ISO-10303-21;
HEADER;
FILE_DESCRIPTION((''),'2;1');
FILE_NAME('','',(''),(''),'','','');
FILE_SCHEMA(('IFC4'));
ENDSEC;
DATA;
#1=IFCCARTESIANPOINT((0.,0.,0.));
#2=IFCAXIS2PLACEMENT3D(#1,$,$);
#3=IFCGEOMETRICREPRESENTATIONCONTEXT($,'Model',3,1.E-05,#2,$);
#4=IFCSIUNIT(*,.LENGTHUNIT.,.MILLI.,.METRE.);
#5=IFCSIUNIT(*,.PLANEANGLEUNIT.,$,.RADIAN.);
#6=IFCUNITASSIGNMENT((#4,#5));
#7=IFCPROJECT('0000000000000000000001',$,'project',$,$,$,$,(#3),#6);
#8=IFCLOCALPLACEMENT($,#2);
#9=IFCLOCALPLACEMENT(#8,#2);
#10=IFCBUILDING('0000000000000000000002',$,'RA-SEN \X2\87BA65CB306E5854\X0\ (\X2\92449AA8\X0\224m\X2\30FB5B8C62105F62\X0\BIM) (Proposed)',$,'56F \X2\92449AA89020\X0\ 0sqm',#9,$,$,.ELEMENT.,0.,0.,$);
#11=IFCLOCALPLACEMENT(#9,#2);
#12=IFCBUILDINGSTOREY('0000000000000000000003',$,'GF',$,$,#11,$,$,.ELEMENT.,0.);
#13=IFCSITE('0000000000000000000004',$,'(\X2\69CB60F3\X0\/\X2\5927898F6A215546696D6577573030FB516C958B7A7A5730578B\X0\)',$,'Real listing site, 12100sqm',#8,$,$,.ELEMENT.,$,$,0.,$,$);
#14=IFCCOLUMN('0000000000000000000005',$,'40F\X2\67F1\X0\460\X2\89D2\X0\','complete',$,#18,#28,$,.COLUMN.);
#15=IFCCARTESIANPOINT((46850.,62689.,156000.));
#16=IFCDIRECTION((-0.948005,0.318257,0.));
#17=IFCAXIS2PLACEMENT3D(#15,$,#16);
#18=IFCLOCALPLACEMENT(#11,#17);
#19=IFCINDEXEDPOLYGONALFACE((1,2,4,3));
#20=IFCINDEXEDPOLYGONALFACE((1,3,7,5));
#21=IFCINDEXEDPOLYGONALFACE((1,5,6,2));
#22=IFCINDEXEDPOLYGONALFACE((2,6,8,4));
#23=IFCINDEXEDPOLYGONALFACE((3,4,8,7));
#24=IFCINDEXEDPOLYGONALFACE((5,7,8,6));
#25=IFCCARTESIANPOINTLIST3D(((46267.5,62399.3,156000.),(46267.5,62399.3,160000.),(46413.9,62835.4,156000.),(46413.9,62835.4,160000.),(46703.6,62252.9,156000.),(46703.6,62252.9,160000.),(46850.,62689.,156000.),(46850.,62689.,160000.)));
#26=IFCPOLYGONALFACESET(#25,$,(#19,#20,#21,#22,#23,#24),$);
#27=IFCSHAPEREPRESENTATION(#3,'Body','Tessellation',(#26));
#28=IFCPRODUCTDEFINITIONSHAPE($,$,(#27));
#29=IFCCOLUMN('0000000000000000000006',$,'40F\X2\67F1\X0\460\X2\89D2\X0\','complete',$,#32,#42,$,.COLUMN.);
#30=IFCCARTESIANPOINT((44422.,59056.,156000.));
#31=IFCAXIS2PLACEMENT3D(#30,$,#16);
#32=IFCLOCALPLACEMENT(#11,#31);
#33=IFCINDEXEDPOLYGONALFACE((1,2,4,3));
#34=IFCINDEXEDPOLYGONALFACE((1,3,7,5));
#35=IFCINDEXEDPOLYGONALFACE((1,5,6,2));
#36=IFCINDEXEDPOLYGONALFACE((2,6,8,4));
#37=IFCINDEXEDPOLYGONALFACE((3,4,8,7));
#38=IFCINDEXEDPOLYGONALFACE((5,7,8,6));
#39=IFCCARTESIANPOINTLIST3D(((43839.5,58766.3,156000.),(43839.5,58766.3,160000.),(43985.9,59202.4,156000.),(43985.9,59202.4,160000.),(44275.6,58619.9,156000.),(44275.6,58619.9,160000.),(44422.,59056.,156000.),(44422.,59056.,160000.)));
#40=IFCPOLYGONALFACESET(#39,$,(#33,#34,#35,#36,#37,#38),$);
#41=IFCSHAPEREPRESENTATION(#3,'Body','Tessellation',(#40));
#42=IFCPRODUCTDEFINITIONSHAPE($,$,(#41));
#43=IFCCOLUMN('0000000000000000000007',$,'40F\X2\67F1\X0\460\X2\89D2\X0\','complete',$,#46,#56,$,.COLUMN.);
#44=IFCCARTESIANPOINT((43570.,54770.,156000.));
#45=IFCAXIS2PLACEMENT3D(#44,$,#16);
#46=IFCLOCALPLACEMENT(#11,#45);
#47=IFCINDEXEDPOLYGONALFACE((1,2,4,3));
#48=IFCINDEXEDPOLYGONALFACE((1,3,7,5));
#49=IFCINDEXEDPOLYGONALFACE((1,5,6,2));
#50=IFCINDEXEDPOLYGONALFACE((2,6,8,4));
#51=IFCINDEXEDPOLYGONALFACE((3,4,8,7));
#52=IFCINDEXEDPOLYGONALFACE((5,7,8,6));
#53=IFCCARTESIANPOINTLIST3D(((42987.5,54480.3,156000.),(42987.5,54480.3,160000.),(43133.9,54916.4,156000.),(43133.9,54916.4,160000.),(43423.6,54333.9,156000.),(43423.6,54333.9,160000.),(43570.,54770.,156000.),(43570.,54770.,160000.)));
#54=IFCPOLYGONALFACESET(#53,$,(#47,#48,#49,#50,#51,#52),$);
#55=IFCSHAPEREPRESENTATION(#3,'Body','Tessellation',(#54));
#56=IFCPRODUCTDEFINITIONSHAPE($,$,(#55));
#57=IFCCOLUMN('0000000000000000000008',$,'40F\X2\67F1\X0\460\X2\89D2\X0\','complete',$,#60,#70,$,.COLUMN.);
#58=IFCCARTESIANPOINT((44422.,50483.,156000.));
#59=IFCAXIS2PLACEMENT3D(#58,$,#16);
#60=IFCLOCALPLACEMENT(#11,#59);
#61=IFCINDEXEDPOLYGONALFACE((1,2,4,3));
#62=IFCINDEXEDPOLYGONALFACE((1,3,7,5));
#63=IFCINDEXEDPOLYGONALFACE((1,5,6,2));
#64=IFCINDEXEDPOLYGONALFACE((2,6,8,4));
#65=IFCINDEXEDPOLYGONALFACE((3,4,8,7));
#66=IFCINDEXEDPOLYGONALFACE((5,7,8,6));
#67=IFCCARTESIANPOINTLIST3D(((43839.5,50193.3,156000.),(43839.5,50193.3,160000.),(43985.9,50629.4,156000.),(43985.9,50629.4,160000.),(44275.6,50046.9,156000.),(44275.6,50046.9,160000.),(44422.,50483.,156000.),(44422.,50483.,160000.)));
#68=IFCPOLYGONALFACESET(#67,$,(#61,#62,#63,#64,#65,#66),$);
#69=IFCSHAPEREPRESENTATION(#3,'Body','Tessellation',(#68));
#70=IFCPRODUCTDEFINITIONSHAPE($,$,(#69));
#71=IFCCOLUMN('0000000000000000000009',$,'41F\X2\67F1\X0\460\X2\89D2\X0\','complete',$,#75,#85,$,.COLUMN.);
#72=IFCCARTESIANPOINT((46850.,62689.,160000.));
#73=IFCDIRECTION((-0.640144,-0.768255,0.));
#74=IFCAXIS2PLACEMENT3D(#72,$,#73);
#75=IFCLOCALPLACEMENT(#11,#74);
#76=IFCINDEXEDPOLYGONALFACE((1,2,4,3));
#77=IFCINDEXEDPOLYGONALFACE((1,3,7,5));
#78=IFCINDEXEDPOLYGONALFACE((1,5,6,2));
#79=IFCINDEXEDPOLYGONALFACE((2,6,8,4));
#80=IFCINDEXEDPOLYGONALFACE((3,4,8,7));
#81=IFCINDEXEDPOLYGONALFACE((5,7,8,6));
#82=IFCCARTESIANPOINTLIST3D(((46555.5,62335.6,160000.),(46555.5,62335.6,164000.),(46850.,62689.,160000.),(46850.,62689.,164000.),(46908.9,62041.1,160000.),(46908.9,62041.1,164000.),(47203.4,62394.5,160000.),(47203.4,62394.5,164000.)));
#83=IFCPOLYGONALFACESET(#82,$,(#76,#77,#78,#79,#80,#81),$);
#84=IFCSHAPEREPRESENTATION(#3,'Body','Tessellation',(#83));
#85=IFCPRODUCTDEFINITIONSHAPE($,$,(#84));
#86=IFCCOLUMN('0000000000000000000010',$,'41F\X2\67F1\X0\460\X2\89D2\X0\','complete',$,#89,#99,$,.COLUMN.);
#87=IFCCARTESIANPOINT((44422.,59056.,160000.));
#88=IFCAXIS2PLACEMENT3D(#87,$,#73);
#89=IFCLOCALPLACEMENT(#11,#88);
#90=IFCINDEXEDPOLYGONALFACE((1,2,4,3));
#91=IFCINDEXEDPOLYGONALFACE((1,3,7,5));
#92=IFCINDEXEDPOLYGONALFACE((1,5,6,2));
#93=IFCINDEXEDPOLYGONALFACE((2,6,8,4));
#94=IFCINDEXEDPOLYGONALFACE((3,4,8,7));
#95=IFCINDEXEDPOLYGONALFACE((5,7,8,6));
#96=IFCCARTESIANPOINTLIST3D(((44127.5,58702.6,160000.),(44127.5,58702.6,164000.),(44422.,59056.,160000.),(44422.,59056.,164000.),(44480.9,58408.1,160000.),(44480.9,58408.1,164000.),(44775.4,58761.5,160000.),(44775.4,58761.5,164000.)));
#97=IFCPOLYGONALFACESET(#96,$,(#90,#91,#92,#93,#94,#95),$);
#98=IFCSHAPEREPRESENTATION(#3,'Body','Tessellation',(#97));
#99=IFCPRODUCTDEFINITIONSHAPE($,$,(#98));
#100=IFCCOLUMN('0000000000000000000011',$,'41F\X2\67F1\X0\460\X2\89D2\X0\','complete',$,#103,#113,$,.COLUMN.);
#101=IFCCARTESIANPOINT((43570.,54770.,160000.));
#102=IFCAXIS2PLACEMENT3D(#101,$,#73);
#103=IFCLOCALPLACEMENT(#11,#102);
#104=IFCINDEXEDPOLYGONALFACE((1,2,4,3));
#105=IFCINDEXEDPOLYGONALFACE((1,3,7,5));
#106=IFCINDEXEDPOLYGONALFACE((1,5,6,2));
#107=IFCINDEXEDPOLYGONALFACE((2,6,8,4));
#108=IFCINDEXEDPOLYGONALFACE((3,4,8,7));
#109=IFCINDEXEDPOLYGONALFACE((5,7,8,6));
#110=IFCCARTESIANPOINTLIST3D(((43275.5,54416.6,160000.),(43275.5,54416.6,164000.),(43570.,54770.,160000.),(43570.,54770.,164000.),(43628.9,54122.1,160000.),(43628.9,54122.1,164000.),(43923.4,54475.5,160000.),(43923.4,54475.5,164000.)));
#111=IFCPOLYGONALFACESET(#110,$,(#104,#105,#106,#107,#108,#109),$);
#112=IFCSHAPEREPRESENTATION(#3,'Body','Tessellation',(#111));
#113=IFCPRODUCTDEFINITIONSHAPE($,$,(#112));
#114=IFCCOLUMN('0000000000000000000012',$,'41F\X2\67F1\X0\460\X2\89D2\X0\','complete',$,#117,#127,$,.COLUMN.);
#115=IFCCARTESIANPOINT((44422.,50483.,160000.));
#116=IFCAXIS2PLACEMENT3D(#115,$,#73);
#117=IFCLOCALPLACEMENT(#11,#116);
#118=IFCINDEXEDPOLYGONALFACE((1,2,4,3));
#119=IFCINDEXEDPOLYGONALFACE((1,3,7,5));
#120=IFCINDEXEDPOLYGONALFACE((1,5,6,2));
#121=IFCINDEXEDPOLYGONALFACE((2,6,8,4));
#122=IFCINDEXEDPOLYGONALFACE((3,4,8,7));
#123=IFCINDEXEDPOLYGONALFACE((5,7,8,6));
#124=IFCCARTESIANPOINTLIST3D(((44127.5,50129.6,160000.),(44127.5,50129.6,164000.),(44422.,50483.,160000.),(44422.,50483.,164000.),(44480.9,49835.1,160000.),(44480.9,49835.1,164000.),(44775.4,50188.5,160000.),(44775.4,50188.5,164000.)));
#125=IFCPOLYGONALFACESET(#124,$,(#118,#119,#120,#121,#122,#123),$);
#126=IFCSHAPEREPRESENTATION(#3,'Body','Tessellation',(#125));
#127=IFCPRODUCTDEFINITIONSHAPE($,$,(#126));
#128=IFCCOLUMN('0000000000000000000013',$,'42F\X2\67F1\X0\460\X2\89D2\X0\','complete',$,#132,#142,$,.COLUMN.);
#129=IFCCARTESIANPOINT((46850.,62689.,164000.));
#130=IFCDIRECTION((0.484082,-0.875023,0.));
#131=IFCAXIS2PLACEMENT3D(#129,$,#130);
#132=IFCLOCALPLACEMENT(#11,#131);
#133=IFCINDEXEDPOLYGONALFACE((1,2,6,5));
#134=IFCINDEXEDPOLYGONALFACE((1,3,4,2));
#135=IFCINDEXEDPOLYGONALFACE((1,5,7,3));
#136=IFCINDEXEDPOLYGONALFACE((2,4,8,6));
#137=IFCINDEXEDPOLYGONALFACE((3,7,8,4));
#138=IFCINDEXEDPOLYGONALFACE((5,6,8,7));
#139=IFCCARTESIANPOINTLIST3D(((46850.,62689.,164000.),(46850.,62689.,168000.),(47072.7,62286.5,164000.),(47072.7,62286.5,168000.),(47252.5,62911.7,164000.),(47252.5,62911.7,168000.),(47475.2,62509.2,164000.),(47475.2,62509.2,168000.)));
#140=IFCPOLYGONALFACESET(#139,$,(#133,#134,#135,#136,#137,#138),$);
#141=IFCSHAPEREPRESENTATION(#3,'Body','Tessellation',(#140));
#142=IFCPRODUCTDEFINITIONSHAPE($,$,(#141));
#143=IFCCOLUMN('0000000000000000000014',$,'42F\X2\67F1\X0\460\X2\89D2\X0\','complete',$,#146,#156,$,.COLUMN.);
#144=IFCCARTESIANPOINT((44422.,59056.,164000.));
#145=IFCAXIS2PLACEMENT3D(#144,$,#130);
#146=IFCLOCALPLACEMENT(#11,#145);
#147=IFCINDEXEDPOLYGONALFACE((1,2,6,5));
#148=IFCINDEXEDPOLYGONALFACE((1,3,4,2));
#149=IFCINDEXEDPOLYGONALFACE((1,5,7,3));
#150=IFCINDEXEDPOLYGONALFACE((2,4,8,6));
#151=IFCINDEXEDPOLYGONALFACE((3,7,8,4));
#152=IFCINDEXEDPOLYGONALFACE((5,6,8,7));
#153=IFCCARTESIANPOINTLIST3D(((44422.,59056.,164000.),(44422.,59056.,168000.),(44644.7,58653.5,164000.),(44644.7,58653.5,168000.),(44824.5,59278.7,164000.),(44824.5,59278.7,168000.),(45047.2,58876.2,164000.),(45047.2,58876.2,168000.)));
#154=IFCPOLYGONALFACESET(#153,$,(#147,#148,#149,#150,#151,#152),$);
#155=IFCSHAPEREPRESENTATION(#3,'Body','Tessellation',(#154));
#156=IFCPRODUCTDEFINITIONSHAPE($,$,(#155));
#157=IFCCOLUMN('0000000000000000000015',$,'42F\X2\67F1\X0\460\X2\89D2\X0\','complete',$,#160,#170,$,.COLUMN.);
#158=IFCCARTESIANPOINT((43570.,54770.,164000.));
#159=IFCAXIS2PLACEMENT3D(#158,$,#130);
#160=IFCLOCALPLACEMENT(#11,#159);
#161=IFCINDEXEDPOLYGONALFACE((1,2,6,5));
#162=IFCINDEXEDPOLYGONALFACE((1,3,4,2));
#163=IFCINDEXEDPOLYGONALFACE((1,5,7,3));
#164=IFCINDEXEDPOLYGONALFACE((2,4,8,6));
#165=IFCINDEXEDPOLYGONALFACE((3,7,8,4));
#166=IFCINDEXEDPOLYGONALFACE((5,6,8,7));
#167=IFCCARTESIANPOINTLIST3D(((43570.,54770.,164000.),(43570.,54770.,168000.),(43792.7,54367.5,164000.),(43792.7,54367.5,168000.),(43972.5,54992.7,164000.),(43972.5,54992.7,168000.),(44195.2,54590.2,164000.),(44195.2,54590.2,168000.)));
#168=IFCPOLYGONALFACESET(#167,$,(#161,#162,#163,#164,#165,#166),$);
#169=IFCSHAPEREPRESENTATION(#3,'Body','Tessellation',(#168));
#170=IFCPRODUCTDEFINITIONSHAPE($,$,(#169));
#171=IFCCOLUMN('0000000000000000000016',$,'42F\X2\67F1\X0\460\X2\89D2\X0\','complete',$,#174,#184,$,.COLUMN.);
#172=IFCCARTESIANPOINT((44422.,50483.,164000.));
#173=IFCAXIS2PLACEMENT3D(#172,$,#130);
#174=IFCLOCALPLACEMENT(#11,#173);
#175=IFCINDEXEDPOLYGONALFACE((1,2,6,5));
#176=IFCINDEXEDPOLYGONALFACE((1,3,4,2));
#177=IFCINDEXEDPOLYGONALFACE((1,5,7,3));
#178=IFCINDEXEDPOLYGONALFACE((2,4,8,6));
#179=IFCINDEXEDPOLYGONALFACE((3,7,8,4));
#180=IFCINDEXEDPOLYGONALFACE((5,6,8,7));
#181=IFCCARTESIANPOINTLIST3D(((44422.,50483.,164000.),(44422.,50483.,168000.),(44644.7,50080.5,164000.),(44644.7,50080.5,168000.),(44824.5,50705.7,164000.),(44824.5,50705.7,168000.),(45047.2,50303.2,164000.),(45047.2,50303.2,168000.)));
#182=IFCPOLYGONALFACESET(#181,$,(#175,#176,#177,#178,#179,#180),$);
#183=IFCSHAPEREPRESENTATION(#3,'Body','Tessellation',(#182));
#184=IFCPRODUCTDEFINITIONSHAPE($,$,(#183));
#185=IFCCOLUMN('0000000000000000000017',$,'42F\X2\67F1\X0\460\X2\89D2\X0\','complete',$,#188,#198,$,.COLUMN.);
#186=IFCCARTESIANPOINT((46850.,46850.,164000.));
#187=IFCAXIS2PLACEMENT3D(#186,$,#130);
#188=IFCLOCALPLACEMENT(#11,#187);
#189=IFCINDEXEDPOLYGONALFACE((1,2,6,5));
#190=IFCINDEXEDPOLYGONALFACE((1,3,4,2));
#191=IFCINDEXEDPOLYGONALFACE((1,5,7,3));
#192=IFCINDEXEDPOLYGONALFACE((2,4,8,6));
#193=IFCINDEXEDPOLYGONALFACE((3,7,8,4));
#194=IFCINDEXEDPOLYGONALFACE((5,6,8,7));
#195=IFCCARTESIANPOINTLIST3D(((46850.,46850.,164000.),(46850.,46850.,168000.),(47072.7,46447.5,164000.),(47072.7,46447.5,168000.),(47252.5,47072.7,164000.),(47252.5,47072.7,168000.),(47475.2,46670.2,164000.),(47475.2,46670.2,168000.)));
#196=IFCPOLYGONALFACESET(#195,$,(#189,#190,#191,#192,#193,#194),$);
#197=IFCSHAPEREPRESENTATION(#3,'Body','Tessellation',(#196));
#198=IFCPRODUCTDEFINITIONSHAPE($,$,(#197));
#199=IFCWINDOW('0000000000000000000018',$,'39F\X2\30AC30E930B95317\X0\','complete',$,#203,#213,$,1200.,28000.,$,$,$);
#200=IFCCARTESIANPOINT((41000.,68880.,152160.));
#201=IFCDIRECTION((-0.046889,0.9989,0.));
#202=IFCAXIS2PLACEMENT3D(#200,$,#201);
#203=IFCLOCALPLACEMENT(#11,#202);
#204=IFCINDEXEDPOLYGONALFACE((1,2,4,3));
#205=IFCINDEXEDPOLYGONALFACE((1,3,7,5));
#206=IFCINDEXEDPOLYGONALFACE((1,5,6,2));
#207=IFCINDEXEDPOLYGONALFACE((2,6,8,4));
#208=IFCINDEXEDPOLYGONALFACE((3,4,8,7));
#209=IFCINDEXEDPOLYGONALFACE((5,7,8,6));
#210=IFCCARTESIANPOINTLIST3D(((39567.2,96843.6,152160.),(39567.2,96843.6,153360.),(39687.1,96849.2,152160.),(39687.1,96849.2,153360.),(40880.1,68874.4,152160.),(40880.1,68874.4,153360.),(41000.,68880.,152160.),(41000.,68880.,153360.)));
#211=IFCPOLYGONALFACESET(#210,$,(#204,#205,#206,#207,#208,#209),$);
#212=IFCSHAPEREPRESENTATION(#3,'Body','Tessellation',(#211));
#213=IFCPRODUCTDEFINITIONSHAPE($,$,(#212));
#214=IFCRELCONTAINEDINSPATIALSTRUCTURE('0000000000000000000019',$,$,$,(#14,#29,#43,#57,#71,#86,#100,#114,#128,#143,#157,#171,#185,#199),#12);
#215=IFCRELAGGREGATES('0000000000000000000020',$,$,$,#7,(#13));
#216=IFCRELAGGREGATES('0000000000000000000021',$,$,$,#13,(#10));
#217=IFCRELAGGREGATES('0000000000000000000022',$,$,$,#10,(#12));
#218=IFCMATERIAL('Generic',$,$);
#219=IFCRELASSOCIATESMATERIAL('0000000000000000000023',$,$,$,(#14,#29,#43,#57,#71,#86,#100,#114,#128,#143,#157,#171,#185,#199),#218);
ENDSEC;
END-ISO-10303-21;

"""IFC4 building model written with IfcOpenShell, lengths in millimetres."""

from ifc_helpers import new_model, si_unit, frame, frame_2d, origin, place, context, project, spatial, rectangle, extrude, material, element, save


model = new_model("IFC4")

# Units and contexts
model_context = context("Model", 3, precision=1e-05, world=origin())
ifc_project = project(units=[si_unit("LENGTHUNIT", "METRE", prefix="MILLI"), si_unit("PLANEANGLEUNIT", "RADIAN")], contexts=[model_context])

# Site, building, storey
site_placement = place(None, origin())
site = spatial("IfcSite", under=ifc_project, at=site_placement, Name="(構想/大規模商業敷地・公開空地型)", ObjectType="Real listing site, 12100sqm", CompositionType="ELEMENT", RefElevation=0.0)
building_placement = place(site_placement, origin())
building = spatial("IfcBuilding", under=site, at=building_placement, Name="RA-SEN 螺旋の塔 (鉄骨224m・完成形BIM) (Proposed)", ObjectType="56F 鉄骨造 0sqm", CompositionType="ELEMENT", ElevationOfRefHeight=0.0, ElevationOfTerrain=0.0)
storey_placement = place(building_placement, origin())
storey = spatial("IfcBuildingStorey", under=building, at=storey_placement, Name="GF", CompositionType="ELEMENT", Elevation=0.0)

# Columns
ifc_material = material(Name="Generic")
column_1_placement = place(storey_placement, frame((46850.0, 62689.0, 156000.0), x_axis=(-0.948005, 0.318257, 0.0)))
element("IfcColumn", 1, at=column_1_placement, inside=storey, material=ifc_material, Name="40F柱460角", Description="complete", PredefinedType="COLUMN", context=model_context, shape_type="SweptSolid", body=[
    extrude(rectangle(XDim=460.0, YDim=460.0, at=frame_2d((230.0, 230.0))), frame((46850.0, 62689.0, 156000.0), x_axis=(-0.948005, 0.318257, 0.0)), (0.0, 0.0, 1.0), 4000.0),
])
column_2_placement = place(storey_placement, frame((44422.0, 59056.0, 156000.0), x_axis=(-0.948005, 0.318257, 0.0)))
element("IfcColumn", 2, at=column_2_placement, inside=storey, material=ifc_material, Name="40F柱460角", Description="complete", PredefinedType="COLUMN", context=model_context, shape_type="SweptSolid", body=[
    extrude(rectangle(XDim=460.0, YDim=460.0, at=frame_2d((230.0, 230.0))), frame((44422.0, 59056.0, 156000.0), x_axis=(-0.948005, 0.318257, 0.0)), (0.0, 0.0, 1.0), 4000.0),
])
column_3_placement = place(storey_placement, frame((43570.0, 54770.0, 156000.0), x_axis=(-0.948005, 0.318257, 0.0)))
element("IfcColumn", 3, at=column_3_placement, inside=storey, material=ifc_material, Name="40F柱460角", Description="complete", PredefinedType="COLUMN", context=model_context, shape_type="SweptSolid", body=[
    extrude(rectangle(XDim=460.0, YDim=460.0, at=frame_2d((230.0, 230.0))), frame((43570.0, 54770.0, 156000.0), x_axis=(-0.948005, 0.318257, 0.0)), (0.0, 0.0, 1.0), 4000.0),
])
column_4_placement = place(storey_placement, frame((44422.0, 50483.0, 156000.0), x_axis=(-0.948005, 0.318257, 0.0)))
element("IfcColumn", 4, at=column_4_placement, inside=storey, material=ifc_material, Name="40F柱460角", Description="complete", PredefinedType="COLUMN", context=model_context, shape_type="SweptSolid", body=[
    extrude(rectangle(XDim=460.0, YDim=460.0, at=frame_2d((230.0, 230.0))), frame((44422.0, 50483.0, 156000.0), x_axis=(-0.948005, 0.318257, 0.0)), (0.0, 0.0, 1.0), 4000.0),
])
column_5_placement = place(storey_placement, frame((46850.0, 62689.0, 160000.0), x_axis=(-0.640144, -0.768255, 0.0)))
element("IfcColumn", 5, at=column_5_placement, inside=storey, material=ifc_material, Name="41F柱460角", Description="complete", PredefinedType="COLUMN", context=model_context, shape_type="SweptSolid", body=[
    extrude(rectangle(XDim=460.0, YDim=460.0, at=frame_2d((230.0, 230.0))), frame((46850.0, 62689.0, 160000.0), x_axis=(-0.640144, -0.768255, 0.0)), (0.0, 0.0, 1.0), 4000.0),
])
column_6_placement = place(storey_placement, frame((44422.0, 59056.0, 160000.0), x_axis=(-0.640144, -0.768255, 0.0)))
element("IfcColumn", 6, at=column_6_placement, inside=storey, material=ifc_material, Name="41F柱460角", Description="complete", PredefinedType="COLUMN", context=model_context, shape_type="SweptSolid", body=[
    extrude(rectangle(XDim=460.0, YDim=460.0, at=frame_2d((230.0, 230.0))), frame((44422.0, 59056.0, 160000.0), x_axis=(-0.640144, -0.768255, 0.0)), (0.0, 0.0, 1.0), 4000.0),
])
column_7_placement = place(storey_placement, frame((43570.0, 54770.0, 160000.0), x_axis=(-0.640144, -0.768255, 0.0)))
element("IfcColumn", 7, at=column_7_placement, inside=storey, material=ifc_material, Name="41F柱460角", Description="complete", PredefinedType="COLUMN", context=model_context, shape_type="SweptSolid", body=[
    extrude(rectangle(XDim=460.0, YDim=460.0, at=frame_2d((230.0, 230.0))), frame((43570.0, 54770.0, 160000.0), x_axis=(-0.640144, -0.768255, 0.0)), (0.0, 0.0, 1.0), 4000.0),
])
column_8_placement = place(storey_placement, frame((44422.0, 50483.0, 160000.0), x_axis=(-0.640144, -0.768255, 0.0)))
element("IfcColumn", 8, at=column_8_placement, inside=storey, material=ifc_material, Name="41F柱460角", Description="complete", PredefinedType="COLUMN", context=model_context, shape_type="SweptSolid", body=[
    extrude(rectangle(XDim=460.0, YDim=460.0, at=frame_2d((230.0, 230.0))), frame((44422.0, 50483.0, 160000.0), x_axis=(-0.640144, -0.768255, 0.0)), (0.0, 0.0, 1.0), 4000.0),
])
column_9_placement = place(storey_placement, frame((46850.0, 62689.0, 164000.0), x_axis=(0.484082, -0.875023, 0.0)))
element("IfcColumn", 9, at=column_9_placement, inside=storey, material=ifc_material, Name="42F柱460角", Description="complete", PredefinedType="COLUMN", context=model_context, shape_type="SweptSolid", body=[
    extrude(rectangle(XDim=460.0, YDim=460.0, at=frame_2d((230.0, 230.0))), frame((46850.0, 62689.0, 164000.0), x_axis=(0.484082, -0.875023, 0.0)), (0.0, 0.0, 1.0), 4000.0),
])
column_10_placement = place(storey_placement, frame((44422.0, 59056.0, 164000.0), x_axis=(0.484082, -0.875023, 0.0)))
element("IfcColumn", 10, at=column_10_placement, inside=storey, material=ifc_material, Name="42F柱460角", Description="complete", PredefinedType="COLUMN", context=model_context, shape_type="SweptSolid", body=[
    extrude(rectangle(XDim=460.0, YDim=460.0, at=frame_2d((230.0, 230.0))), frame((44422.0, 59056.0, 164000.0), x_axis=(0.484082, -0.875023, 0.0)), (0.0, 0.0, 1.0), 4000.0),
])
column_11_placement = place(storey_placement, frame((43570.0, 54770.0, 164000.0), x_axis=(0.484082, -0.875023, 0.0)))
element("IfcColumn", 11, at=column_11_placement, inside=storey, material=ifc_material, Name="42F柱460角", Description="complete", PredefinedType="COLUMN", context=model_context, shape_type="SweptSolid", body=[
    extrude(rectangle(XDim=460.0, YDim=460.0, at=frame_2d((230.0, 230.0))), frame((43570.0, 54770.0, 164000.0), x_axis=(0.484082, -0.875023, 0.0)), (0.0, 0.0, 1.0), 4000.0),
])
column_12_placement = place(storey_placement, frame((44422.0, 50483.0, 164000.0), x_axis=(0.484082, -0.875023, 0.0)))
element("IfcColumn", 12, at=column_12_placement, inside=storey, material=ifc_material, Name="42F柱460角", Description="complete", PredefinedType="COLUMN", context=model_context, shape_type="SweptSolid", body=[
    extrude(rectangle(XDim=460.0, YDim=460.0, at=frame_2d((230.0, 230.0))), frame((44422.0, 50483.0, 164000.0), x_axis=(0.484082, -0.875023, 0.0)), (0.0, 0.0, 1.0), 4000.0),
])
column_13_placement = place(storey_placement, frame((46850.0, 46850.0, 164000.0), x_axis=(0.484082, -0.875023, 0.0)))
element("IfcColumn", 13, at=column_13_placement, inside=storey, material=ifc_material, Name="42F柱460角", Description="complete", PredefinedType="COLUMN", context=model_context, shape_type="SweptSolid", body=[
    extrude(rectangle(XDim=460.0, YDim=460.0, at=frame_2d((230.0, 230.0))), frame((46850.0, 46850.0, 164000.0), x_axis=(0.484082, -0.875023, 0.0)), (0.0, 0.0, 1.0), 4000.0),
])

# Window
window_1_placement = place(storey_placement, frame((41000.0, 68880.0, 152160.0), x_axis=(-0.046889, 0.9989, 0.0)))
element("IfcWindow", 14, at=window_1_placement, inside=storey, material=ifc_material, Name="39Fガラス北", Description="complete", OverallHeight=1200.0, OverallWidth=28000.0, context=model_context, shape_type="SweptSolid", body=[
    extrude(rectangle(XDim=28000.0, YDim=120.0, at=frame_2d((14000.0, 60.0))), frame((41000.0, 68880.0, 152160.0), x_axis=(-0.046889, 0.9989, 0.0)), (0.0, 0.0, 1.0), 1200.0),
])

save(model, "model.ifc")
